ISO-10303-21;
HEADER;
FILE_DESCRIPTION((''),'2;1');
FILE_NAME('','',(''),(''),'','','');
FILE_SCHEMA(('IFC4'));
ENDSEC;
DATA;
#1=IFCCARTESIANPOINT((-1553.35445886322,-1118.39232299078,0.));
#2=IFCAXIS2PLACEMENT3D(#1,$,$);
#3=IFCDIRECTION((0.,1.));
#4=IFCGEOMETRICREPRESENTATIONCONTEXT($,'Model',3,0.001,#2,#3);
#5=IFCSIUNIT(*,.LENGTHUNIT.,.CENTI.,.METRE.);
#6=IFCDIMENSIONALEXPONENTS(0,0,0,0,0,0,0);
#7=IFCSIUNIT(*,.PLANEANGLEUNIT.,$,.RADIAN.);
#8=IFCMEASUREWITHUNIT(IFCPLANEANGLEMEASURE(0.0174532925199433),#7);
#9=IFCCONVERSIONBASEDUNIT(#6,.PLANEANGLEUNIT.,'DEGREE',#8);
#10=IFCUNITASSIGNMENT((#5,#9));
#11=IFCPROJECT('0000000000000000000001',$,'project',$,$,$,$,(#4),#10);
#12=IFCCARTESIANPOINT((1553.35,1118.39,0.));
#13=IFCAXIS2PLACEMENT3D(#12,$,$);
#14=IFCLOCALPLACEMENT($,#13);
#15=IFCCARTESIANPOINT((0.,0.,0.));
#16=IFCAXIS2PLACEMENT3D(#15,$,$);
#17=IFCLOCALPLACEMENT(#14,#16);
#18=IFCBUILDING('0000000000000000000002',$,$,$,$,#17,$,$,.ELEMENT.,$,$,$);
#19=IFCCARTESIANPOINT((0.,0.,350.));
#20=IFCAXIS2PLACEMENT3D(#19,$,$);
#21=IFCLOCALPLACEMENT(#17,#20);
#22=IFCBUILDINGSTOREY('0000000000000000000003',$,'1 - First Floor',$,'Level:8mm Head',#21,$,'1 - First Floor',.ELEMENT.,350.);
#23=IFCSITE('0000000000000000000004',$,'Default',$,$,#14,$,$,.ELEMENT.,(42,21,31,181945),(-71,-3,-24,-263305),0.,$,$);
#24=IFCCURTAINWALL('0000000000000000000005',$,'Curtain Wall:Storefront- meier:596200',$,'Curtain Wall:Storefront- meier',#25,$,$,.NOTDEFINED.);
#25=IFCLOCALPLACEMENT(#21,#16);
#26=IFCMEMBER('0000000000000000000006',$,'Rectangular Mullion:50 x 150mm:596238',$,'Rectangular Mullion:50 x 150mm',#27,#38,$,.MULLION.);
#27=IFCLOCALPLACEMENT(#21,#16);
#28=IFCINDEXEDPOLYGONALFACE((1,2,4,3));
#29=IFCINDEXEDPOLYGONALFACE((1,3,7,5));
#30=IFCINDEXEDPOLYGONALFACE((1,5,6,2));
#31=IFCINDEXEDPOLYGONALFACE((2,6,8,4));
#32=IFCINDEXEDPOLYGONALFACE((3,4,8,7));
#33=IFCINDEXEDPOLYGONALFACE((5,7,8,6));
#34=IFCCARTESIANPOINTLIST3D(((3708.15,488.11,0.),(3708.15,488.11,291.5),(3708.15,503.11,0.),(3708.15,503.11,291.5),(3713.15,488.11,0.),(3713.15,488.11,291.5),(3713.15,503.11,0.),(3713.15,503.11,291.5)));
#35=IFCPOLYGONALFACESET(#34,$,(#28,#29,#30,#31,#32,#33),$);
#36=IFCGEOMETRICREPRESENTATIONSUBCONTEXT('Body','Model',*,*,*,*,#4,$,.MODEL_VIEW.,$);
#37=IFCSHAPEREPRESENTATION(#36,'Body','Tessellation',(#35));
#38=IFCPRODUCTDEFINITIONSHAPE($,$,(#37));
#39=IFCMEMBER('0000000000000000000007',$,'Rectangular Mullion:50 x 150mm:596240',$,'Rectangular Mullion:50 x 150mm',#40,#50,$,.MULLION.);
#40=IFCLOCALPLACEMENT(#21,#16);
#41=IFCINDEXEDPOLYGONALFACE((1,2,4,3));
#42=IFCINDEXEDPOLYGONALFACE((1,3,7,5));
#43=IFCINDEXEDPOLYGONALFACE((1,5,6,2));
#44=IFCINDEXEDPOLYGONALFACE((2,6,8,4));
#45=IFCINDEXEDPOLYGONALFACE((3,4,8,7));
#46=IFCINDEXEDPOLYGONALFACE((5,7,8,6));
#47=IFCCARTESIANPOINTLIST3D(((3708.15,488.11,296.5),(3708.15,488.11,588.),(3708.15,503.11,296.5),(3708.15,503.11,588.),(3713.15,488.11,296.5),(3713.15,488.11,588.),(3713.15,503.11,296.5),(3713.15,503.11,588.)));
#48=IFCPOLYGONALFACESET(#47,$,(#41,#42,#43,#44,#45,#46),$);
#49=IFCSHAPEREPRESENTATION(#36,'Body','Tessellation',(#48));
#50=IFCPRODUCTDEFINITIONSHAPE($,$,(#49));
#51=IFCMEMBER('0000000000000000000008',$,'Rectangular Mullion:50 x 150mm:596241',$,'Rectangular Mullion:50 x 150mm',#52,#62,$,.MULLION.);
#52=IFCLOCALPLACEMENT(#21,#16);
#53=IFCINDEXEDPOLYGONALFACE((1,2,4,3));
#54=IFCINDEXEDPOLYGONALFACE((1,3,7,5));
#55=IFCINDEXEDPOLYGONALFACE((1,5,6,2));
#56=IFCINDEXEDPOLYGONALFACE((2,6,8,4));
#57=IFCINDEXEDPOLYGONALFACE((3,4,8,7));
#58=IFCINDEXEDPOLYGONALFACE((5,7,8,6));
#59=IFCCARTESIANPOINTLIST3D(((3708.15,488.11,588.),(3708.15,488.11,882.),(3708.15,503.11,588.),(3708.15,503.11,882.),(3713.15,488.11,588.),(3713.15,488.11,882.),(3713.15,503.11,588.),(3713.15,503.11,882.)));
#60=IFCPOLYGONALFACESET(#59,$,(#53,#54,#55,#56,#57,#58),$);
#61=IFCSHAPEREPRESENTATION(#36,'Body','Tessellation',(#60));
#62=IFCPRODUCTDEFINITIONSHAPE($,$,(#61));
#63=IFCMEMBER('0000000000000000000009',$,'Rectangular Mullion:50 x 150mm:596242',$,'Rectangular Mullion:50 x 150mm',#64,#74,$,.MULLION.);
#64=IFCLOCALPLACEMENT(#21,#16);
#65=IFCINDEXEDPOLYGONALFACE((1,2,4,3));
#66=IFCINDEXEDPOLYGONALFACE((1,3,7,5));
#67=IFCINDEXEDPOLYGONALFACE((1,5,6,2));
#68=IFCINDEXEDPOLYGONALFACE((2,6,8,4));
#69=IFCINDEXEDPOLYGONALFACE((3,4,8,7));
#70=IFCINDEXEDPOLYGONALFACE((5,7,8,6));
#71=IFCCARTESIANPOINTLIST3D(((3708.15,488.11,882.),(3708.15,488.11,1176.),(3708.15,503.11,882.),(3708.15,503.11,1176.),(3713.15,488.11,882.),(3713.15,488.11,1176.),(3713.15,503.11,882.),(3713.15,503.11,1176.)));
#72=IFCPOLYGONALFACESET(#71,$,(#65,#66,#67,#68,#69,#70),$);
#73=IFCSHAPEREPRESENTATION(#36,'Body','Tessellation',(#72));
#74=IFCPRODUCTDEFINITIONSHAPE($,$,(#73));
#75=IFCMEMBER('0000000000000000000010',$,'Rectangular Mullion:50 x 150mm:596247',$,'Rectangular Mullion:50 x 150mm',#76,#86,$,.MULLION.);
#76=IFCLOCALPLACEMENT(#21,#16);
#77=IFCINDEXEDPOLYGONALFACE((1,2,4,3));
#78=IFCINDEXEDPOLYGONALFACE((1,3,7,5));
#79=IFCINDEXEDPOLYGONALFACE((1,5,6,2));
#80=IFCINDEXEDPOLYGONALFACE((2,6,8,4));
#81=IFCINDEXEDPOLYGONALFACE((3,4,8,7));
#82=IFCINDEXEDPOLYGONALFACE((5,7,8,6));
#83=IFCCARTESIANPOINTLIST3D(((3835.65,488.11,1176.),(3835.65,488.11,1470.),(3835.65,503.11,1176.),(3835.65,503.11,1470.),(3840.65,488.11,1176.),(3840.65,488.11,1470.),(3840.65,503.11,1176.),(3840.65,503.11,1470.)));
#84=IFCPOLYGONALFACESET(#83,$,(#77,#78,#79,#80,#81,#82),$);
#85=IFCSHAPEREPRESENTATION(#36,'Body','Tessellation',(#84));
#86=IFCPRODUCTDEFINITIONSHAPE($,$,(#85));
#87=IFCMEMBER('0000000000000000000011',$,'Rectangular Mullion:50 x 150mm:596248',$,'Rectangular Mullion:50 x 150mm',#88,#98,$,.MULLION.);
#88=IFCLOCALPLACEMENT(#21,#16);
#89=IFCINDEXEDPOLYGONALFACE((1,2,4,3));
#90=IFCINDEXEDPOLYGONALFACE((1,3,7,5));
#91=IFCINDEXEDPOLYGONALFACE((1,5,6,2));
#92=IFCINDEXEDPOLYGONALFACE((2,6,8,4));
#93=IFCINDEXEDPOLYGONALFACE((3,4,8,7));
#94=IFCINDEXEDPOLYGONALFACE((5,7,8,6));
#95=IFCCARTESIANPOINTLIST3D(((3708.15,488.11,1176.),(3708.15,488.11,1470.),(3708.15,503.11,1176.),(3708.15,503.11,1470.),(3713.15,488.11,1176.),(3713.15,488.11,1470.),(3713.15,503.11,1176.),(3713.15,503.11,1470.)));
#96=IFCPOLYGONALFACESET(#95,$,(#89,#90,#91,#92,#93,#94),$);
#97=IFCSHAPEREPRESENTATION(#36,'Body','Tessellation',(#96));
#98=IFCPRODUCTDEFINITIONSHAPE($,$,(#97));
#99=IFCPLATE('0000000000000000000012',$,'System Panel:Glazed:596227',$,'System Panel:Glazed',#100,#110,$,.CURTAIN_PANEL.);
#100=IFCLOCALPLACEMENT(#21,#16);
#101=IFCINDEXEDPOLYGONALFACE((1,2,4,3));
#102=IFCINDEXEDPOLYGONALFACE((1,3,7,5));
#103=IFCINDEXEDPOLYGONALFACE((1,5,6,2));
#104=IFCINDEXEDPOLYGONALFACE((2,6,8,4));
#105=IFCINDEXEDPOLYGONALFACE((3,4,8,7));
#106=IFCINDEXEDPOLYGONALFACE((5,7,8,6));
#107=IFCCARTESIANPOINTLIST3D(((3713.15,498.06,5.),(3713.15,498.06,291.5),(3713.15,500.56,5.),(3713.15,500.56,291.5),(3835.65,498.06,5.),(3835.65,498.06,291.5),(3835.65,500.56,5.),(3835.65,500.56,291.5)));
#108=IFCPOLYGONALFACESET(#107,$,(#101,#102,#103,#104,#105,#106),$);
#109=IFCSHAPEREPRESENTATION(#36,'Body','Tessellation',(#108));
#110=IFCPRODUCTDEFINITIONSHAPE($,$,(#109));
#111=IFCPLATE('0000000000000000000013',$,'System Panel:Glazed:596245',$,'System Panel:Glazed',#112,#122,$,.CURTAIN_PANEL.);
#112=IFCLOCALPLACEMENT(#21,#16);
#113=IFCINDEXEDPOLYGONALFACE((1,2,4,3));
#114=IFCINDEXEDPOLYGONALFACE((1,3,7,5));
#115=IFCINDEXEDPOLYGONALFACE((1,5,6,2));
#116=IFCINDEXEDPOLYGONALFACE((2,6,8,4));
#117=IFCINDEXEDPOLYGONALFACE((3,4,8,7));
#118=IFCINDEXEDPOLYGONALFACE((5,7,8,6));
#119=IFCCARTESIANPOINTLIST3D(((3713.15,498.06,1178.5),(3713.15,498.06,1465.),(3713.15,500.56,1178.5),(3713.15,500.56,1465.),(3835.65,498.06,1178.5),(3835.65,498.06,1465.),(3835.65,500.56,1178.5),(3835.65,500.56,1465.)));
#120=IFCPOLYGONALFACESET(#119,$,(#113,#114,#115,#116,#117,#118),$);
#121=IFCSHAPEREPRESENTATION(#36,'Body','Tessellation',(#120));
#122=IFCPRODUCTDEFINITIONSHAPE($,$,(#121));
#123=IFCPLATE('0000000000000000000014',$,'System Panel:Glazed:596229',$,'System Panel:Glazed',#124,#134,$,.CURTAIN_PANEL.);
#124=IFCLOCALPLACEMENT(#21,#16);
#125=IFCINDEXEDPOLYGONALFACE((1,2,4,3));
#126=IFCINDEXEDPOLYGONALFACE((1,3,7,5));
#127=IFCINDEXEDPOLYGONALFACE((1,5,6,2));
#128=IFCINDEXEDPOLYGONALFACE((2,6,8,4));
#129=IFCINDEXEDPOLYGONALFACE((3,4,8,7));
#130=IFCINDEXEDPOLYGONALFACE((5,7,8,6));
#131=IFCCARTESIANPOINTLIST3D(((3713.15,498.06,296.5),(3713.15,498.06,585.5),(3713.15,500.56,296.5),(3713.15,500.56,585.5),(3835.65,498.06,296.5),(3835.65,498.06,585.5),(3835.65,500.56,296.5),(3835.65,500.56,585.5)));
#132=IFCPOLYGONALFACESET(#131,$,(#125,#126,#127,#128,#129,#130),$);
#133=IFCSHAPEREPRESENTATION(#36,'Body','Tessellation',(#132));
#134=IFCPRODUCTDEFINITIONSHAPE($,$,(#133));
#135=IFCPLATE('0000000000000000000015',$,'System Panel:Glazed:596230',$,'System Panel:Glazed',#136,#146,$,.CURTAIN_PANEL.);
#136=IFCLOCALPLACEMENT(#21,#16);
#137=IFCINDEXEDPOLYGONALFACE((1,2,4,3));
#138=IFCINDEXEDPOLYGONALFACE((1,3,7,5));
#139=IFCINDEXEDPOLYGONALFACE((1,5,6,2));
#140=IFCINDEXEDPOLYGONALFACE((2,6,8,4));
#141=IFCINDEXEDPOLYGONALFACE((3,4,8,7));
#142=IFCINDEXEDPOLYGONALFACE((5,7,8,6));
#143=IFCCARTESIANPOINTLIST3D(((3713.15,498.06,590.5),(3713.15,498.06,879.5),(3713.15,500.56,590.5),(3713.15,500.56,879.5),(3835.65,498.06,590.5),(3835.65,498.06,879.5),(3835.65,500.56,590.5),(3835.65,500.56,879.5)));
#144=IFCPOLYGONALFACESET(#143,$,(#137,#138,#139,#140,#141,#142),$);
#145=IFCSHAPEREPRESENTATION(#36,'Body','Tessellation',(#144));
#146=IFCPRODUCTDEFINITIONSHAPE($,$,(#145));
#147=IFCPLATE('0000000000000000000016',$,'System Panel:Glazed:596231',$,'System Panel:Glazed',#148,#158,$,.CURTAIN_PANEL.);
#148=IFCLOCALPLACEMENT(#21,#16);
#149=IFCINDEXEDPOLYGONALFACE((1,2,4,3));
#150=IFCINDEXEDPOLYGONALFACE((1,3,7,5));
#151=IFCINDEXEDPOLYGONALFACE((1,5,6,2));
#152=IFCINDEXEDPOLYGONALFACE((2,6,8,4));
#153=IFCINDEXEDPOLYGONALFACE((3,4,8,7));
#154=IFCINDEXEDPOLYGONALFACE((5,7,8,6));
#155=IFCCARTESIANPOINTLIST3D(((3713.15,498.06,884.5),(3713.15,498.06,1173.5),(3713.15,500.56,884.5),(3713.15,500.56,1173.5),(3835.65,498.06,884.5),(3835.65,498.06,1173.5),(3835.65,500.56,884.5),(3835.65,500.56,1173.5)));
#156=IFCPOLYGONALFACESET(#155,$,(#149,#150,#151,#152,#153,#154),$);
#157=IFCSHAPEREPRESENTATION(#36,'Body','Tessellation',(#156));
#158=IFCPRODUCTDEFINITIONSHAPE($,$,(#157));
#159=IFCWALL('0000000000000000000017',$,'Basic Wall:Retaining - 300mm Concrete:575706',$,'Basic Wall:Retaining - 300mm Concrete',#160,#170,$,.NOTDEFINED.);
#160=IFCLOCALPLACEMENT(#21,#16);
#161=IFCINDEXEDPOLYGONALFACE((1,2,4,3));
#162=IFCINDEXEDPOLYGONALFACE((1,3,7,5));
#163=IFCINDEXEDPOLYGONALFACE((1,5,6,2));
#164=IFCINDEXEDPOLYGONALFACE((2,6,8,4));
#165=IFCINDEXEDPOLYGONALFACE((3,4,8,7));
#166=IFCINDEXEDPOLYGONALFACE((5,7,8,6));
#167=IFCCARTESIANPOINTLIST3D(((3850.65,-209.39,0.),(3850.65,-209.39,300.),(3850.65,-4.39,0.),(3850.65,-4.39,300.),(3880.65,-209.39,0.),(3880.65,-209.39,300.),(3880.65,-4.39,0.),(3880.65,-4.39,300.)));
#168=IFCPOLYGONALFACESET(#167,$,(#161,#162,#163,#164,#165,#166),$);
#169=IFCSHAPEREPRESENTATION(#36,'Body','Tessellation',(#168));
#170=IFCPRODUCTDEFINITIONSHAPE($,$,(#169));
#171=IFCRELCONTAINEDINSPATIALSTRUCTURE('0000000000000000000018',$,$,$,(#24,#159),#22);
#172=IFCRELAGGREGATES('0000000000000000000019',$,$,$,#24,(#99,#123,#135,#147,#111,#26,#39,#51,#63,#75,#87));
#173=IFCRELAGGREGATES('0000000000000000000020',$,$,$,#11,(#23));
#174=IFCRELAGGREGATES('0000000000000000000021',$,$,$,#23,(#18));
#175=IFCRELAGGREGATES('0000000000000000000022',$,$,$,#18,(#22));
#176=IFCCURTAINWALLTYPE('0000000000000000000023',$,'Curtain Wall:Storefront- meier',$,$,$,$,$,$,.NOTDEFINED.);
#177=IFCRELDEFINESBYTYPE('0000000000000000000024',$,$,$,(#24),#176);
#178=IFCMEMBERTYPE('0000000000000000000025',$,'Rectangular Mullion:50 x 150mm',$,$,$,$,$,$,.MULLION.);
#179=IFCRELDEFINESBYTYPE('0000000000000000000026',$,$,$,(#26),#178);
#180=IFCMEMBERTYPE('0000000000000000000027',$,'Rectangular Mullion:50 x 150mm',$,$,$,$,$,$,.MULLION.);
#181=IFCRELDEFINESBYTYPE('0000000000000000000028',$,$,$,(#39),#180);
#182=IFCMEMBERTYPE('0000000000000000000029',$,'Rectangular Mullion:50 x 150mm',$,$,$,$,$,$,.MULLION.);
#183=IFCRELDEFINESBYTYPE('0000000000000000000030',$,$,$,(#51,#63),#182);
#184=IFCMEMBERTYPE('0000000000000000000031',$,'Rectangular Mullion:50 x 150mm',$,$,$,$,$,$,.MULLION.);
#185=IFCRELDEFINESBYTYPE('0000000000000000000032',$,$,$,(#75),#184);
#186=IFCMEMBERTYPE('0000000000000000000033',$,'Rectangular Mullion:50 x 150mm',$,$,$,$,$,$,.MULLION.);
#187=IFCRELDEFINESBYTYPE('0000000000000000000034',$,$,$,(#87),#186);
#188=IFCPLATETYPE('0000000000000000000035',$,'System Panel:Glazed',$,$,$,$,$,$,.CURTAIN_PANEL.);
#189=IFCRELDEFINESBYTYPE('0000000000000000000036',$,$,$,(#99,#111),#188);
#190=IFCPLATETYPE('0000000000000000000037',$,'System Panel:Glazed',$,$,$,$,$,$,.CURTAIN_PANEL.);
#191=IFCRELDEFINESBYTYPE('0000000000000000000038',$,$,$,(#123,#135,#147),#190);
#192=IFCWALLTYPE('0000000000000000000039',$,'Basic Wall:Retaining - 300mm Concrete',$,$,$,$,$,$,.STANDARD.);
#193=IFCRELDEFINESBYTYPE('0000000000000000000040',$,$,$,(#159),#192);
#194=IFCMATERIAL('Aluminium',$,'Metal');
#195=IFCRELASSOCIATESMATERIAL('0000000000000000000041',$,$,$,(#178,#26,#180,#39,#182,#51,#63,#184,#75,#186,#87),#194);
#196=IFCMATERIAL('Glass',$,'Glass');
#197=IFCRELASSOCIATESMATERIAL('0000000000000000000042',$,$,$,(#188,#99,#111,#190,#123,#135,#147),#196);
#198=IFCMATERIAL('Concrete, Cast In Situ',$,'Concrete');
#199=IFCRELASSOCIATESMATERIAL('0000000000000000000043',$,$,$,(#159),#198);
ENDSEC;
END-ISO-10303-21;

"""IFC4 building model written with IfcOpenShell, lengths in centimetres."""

from ifc_helpers import new_model, entity, si_unit, converted_unit, direction, frame, origin, place, context, subcontext, project, spatial, indexed_curve, outline, extrude, source, transform, mapped, material, type_object, type_shapes, element, aggregate, save


model = new_model("IFC4")

# Units and contexts
model_context = context("Model", 3, precision=0.001, world=frame((-1553.35445886322, -1118.39232299078, 0.0)), true_north=direction((0.0, 1.0)))
body_context = subcontext(model_context, "Body", "Model", "MODEL_VIEW")
ifc_project = project(units=[si_unit("LENGTHUNIT", "METRE", prefix="CENTI"), converted_unit("PLANEANGLEUNIT", "DEGREE", entity("IfcPlaneAngleMeasure", 0.0174532925199433), si_unit("PLANEANGLEUNIT", "RADIAN"), dimensions=[0, 0, 0, 0, 0, 0, 0])], contexts=[model_context])

# Site, building, storey
site_placement = place(None, frame((1553.35, 1118.39, 0.0)))
site = spatial("IfcSite", under=ifc_project, at=site_placement, Name="Default", CompositionType="ELEMENT", RefLatitude=(42, 21, 31, 181945), RefLongitude=(-71, -3, -24, -263305), RefElevation=0.0)
building_placement = place(site_placement, origin())
building = spatial("IfcBuilding", under=site, at=building_placement, CompositionType="ELEMENT")
storey_placement = place(building_placement, frame((0.0, 0.0, 350.0)))
storey = spatial("IfcBuildingStorey", under=building, at=storey_placement, Name="1 - First Floor", ObjectType="Level:8mm Head", LongName="1 - First Floor", CompositionType="ELEMENT", Elevation=350.0)

# Curtain wall, members, plates
curtain_wall_type = type_object("IfcCurtainWallType", Name="Curtain Wall:Storefront- meier", PredefinedType="NOTDEFINED")
curtain_wall_placement = place(storey_placement, frame((0.0, 0.0, -350.0)))
curtain_wall = element("IfcCurtainWall", 1, at=curtain_wall_placement, inside=storey, type_object=curtain_wall_type, Name="Curtain Wall:Storefront- meier:596200", ObjectType="Curtain Wall:Storefront- meier", PredefinedType="NOTDEFINED")
ifc_material_1 = material(Name="Aluminium", Category="Metal")
member_type_1 = type_object("IfcMemberType", Name="Rectangular Mullion:50 x 150mm", PredefinedType="MULLION", material=ifc_material_1)
shared_shape_1 = source(origin(), body_context, "Body", "SweptSolid", [
    extrude(outline(indexed_curve([(-2.5, -7.5), (2.5, -7.5), (2.5, 7.5), (-2.5, 7.5), (-2.5, -7.5)], self_intersect=False)), frame((0.0, 0.0, -291.5), z_axis=(0.0, 0.0, 1.0), x_axis=(-1.0, 0.0, 0.0)), (0.0, 0.0, 1.0), 291.5),
])
type_shapes(member_type_1, [shared_shape_1])
member_1_placement = place(curtain_wall_placement, frame((3710.65, 495.61, 350.0), z_axis=(0.0, 0.0, -1.0), x_axis=(1.0, 0.0, 0.0)))
member_1 = element("IfcMember", 2, at=member_1_placement, type_object=member_type_1, material=ifc_material_1, Name="Rectangular Mullion:50 x 150mm:596238", ObjectType="Rectangular Mullion:50 x 150mm", PredefinedType="MULLION", context=body_context, shape_type="MappedRepresentation", body=[
    mapped(shared_shape_1, transform((0.0, 0.0, 0.0), scale=1.0)),
])
member_type_2 = type_object("IfcMemberType", Name="Rectangular Mullion:50 x 150mm", PredefinedType="MULLION", material=ifc_material_1)
shared_shape_2 = source(origin(), body_context, "Body", "SweptSolid", [
    extrude(outline(indexed_curve([(-2.5, -7.5), (2.5, -7.5), (2.5, 7.5), (-2.5, 7.5), (-2.5, -7.5)], self_intersect=False)), frame((0.0, 0.0, -291.5), z_axis=(0.0, 0.0, 1.0), x_axis=(-1.0, 0.0, 0.0)), (0.0, 0.0, 1.0), 291.5),
])
type_shapes(member_type_2, [shared_shape_2])
member_2_placement = place(curtain_wall_placement, frame((3710.65, 495.61, 646.5), z_axis=(0.0, 0.0, -1.0), x_axis=(1.0, 0.0, 0.0)))
member_2 = element("IfcMember", 3, at=member_2_placement, type_object=member_type_2, material=ifc_material_1, Name="Rectangular Mullion:50 x 150mm:596240", ObjectType="Rectangular Mullion:50 x 150mm", PredefinedType="MULLION", context=body_context, shape_type="MappedRepresentation", body=[
    mapped(shared_shape_2, transform((0.0, 0.0, 0.0), scale=1.0)),
])
member_type_3 = type_object("IfcMemberType", Name="Rectangular Mullion:50 x 150mm", PredefinedType="MULLION", material=ifc_material_1)
shared_shape_3 = source(origin(), body_context, "Body", "SweptSolid", [
    extrude(outline(indexed_curve([(-2.5, -7.5), (2.5, -7.5), (2.5, 7.5), (-2.5, 7.5), (-2.5, -7.5)], self_intersect=False)), frame((0.0, 0.0, -294.0), z_axis=(0.0, 0.0, 1.0), x_axis=(-1.0, 0.0, 0.0)), (0.0, 0.0, 1.0), 294.0),
])
type_shapes(member_type_3, [shared_shape_3])
member_3_placement = place(curtain_wall_placement, frame((3710.65, 495.61, 938.0), z_axis=(0.0, 0.0, -1.0), x_axis=(1.0, 0.0, 0.0)))
member_3 = element("IfcMember", 4, at=member_3_placement, type_object=member_type_3, material=ifc_material_1, Name="Rectangular Mullion:50 x 150mm:596241", ObjectType="Rectangular Mullion:50 x 150mm", PredefinedType="MULLION", context=body_context, shape_type="MappedRepresentation", body=[
    mapped(shared_shape_3, transform((0.0, 0.0, 0.0), scale=1.0)),
])
member_4_placement = place(curtain_wall_placement, frame((3710.65, 495.61, 1232.0), z_axis=(0.0, 0.0, -1.0), x_axis=(1.0, 0.0, 0.0)))
member_4 = element("IfcMember", 5, at=member_4_placement, type_object=member_type_3, material=ifc_material_1, Name="Rectangular Mullion:50 x 150mm:596242", ObjectType="Rectangular Mullion:50 x 150mm", PredefinedType="MULLION", context=body_context, shape_type="MappedRepresentation", body=[
    mapped(shared_shape_3, transform((0.0, 0.0, 0.0), scale=1.0)),
])
member_type_4 = type_object("IfcMemberType", Name="Rectangular Mullion:50 x 150mm", PredefinedType="MULLION", material=ifc_material_1)
shared_shape_4 = source(origin(), body_context, "Body", "SweptSolid", [
    extrude(outline(indexed_curve([(-2.5, -7.5), (2.5, -7.5), (2.5, 7.5), (-2.5, 7.5), (-2.5, -7.5)], self_intersect=False)), frame((-2.5, 0.0, -294.0), z_axis=(0.0, 0.0, 1.0), x_axis=(-1.0, 0.0, 0.0)), (0.0, 0.0, 1.0), 294.0),
])
type_shapes(member_type_4, [shared_shape_4])
member_5_placement = place(curtain_wall_placement, frame((3840.65, 495.61, 1526.0), z_axis=(0.0, 0.0, -1.0), x_axis=(1.0, 0.0, 0.0)))
member_5 = element("IfcMember", 6, at=member_5_placement, type_object=member_type_4, material=ifc_material_1, Name="Rectangular Mullion:50 x 150mm:596247", ObjectType="Rectangular Mullion:50 x 150mm", PredefinedType="MULLION", context=body_context, shape_type="MappedRepresentation", body=[
    mapped(shared_shape_4, transform((0.0, 0.0, 0.0), scale=1.0)),
])
member_type_5 = type_object("IfcMemberType", Name="Rectangular Mullion:50 x 150mm", PredefinedType="MULLION", material=ifc_material_1)
shared_shape_5 = source(origin(), body_context, "Body", "SweptSolid", [
    extrude(outline(indexed_curve([(-2.5, -7.5), (2.5, -7.5), (2.5, 7.5), (-2.5, 7.5), (-2.5, -7.5)], self_intersect=False)), frame((0.0, 0.0, -294.0), z_axis=(0.0, 0.0, 1.0), x_axis=(-1.0, 0.0, 0.0)), (0.0, 0.0, 1.0), 294.0),
])
type_shapes(member_type_5, [shared_shape_5])
member_6_placement = place(curtain_wall_placement, frame((3710.65, 495.61, 1526.0), z_axis=(0.0, 0.0, -1.0), x_axis=(1.0, 0.0, 0.0)))
member_6 = element("IfcMember", 7, at=member_6_placement, type_object=member_type_5, material=ifc_material_1, Name="Rectangular Mullion:50 x 150mm:596248", ObjectType="Rectangular Mullion:50 x 150mm", PredefinedType="MULLION", context=body_context, shape_type="MappedRepresentation", body=[
    mapped(shared_shape_5, transform((0.0, 0.0, 0.0), scale=1.0)),
])
ifc_material_2 = material(Name="Glass", Category="Glass")
plate_type_1 = type_object("IfcPlateType", Name="System Panel:Glazed", PredefinedType="CURTAIN_PANEL", material=ifc_material_2)
shared_shape_6 = source(origin(), body_context, "Body", "SweptSolid", [
    extrude(outline(indexed_curve([(-1.25, -61.25), (1.25, -61.25), (1.25, 61.25), (-1.25, 61.25), (-1.25, -61.25)], self_intersect=False)), frame((0.0, 3.7, 0.0), z_axis=(0.0, 0.0, 1.0), x_axis=(0.0, 1.0, 0.0)), (0.0, 0.0, 1.0), 286.5),
])
type_shapes(plate_type_1, [shared_shape_6])
plate_1_placement = place(curtain_wall_placement, frame((3774.4, 495.61, 355.0)))
plate_1 = element("IfcPlate", 8, at=plate_1_placement, type_object=plate_type_1, material=ifc_material_2, Name="System Panel:Glazed:596227", ObjectType="System Panel:Glazed", PredefinedType="CURTAIN_PANEL", context=body_context, shape_type="MappedRepresentation", body=[
    mapped(shared_shape_6, transform((0.0, 0.0, 0.0), scale=1.0)),
])
plate_2_placement = place(curtain_wall_placement, frame((3774.4, 495.61, 1528.5)))
plate_2 = element("IfcPlate", 9, at=plate_2_placement, type_object=plate_type_1, material=ifc_material_2, Name="System Panel:Glazed:596245", ObjectType="System Panel:Glazed", PredefinedType="CURTAIN_PANEL", context=body_context, shape_type="MappedRepresentation", body=[
    mapped(shared_shape_6, transform((0.0, 0.0, 0.0), scale=1.0)),
])
plate_type_2 = type_object("IfcPlateType", Name="System Panel:Glazed", PredefinedType="CURTAIN_PANEL", material=ifc_material_2)
shared_shape_7 = source(origin(), body_context, "Body", "SweptSolid", [
    extrude(outline(indexed_curve([(-1.25, -61.25), (1.25, -61.25), (1.25, 61.25), (-1.25, 61.25), (-1.25, -61.25)], self_intersect=False)), frame((0.0, 3.7, 0.0), z_axis=(0.0, 0.0, 1.0), x_axis=(0.0, 1.0, 0.0)), (0.0, 0.0, 1.0), 289.0),
])
type_shapes(plate_type_2, [shared_shape_7])
plate_3_placement = place(curtain_wall_placement, frame((3774.4, 495.61, 646.5)))
plate_3 = element("IfcPlate", 10, at=plate_3_placement, type_object=plate_type_2, material=ifc_material_2, Name="System Panel:Glazed:596229", ObjectType="System Panel:Glazed", PredefinedType="CURTAIN_PANEL", context=body_context, shape_type="MappedRepresentation", body=[
    mapped(shared_shape_7, transform((0.0, 0.0, 0.0), scale=1.0)),
])
plate_4_placement = place(curtain_wall_placement, frame((3774.4, 495.61, 940.5)))
plate_4 = element("IfcPlate", 11, at=plate_4_placement, type_object=plate_type_2, material=ifc_material_2, Name="System Panel:Glazed:596230", ObjectType="System Panel:Glazed", PredefinedType="CURTAIN_PANEL", context=body_context, shape_type="MappedRepresentation", body=[
    mapped(shared_shape_7, transform((0.0, 0.0, 0.0), scale=1.0)),
])
plate_5_placement = place(curtain_wall_placement, frame((3774.4, 495.61, 1234.5)))
plate_5 = element("IfcPlate", 12, at=plate_5_placement, type_object=plate_type_2, material=ifc_material_2, Name="System Panel:Glazed:596231", ObjectType="System Panel:Glazed", PredefinedType="CURTAIN_PANEL", context=body_context, shape_type="MappedRepresentation", body=[
    mapped(shared_shape_7, transform((0.0, 0.0, 0.0), scale=1.0)),
])
aggregate(curtain_wall, [plate_1, plate_3, plate_4, plate_5, plate_2, member_1, member_2, member_3, member_4, member_5, member_6])

# Wall
ifc_material_3 = material(Name="Concrete, Cast In Situ", Category="Concrete")
wall_type_1 = type_object("IfcWallType", Name="Basic Wall:Retaining - 300mm Concrete", PredefinedType="STANDARD")
wall_1_placement = place(storey_placement, frame((3865.65, -209.39, 0.0), z_axis=(0.0, 0.0, 1.0), x_axis=(0.0, 1.0, 0.0)))
element("IfcWall", 13, at=wall_1_placement, inside=storey, type_object=wall_type_1, material=ifc_material_3, Name="Basic Wall:Retaining - 300mm Concrete:575706", ObjectType="Basic Wall:Retaining - 300mm Concrete", PredefinedType="NOTDEFINED", context=body_context, shape_type="SweptSolid", body=[
    extrude(outline(indexed_curve([(205.0, 15.0), (0.0, 15.0), (0.0, -15.0), (205.0, -15.0), (205.0, 15.0)], self_intersect=False)), origin(), (0.0, 0.0, 1.0), 300.0),
])

save(model, "model.ifc")
